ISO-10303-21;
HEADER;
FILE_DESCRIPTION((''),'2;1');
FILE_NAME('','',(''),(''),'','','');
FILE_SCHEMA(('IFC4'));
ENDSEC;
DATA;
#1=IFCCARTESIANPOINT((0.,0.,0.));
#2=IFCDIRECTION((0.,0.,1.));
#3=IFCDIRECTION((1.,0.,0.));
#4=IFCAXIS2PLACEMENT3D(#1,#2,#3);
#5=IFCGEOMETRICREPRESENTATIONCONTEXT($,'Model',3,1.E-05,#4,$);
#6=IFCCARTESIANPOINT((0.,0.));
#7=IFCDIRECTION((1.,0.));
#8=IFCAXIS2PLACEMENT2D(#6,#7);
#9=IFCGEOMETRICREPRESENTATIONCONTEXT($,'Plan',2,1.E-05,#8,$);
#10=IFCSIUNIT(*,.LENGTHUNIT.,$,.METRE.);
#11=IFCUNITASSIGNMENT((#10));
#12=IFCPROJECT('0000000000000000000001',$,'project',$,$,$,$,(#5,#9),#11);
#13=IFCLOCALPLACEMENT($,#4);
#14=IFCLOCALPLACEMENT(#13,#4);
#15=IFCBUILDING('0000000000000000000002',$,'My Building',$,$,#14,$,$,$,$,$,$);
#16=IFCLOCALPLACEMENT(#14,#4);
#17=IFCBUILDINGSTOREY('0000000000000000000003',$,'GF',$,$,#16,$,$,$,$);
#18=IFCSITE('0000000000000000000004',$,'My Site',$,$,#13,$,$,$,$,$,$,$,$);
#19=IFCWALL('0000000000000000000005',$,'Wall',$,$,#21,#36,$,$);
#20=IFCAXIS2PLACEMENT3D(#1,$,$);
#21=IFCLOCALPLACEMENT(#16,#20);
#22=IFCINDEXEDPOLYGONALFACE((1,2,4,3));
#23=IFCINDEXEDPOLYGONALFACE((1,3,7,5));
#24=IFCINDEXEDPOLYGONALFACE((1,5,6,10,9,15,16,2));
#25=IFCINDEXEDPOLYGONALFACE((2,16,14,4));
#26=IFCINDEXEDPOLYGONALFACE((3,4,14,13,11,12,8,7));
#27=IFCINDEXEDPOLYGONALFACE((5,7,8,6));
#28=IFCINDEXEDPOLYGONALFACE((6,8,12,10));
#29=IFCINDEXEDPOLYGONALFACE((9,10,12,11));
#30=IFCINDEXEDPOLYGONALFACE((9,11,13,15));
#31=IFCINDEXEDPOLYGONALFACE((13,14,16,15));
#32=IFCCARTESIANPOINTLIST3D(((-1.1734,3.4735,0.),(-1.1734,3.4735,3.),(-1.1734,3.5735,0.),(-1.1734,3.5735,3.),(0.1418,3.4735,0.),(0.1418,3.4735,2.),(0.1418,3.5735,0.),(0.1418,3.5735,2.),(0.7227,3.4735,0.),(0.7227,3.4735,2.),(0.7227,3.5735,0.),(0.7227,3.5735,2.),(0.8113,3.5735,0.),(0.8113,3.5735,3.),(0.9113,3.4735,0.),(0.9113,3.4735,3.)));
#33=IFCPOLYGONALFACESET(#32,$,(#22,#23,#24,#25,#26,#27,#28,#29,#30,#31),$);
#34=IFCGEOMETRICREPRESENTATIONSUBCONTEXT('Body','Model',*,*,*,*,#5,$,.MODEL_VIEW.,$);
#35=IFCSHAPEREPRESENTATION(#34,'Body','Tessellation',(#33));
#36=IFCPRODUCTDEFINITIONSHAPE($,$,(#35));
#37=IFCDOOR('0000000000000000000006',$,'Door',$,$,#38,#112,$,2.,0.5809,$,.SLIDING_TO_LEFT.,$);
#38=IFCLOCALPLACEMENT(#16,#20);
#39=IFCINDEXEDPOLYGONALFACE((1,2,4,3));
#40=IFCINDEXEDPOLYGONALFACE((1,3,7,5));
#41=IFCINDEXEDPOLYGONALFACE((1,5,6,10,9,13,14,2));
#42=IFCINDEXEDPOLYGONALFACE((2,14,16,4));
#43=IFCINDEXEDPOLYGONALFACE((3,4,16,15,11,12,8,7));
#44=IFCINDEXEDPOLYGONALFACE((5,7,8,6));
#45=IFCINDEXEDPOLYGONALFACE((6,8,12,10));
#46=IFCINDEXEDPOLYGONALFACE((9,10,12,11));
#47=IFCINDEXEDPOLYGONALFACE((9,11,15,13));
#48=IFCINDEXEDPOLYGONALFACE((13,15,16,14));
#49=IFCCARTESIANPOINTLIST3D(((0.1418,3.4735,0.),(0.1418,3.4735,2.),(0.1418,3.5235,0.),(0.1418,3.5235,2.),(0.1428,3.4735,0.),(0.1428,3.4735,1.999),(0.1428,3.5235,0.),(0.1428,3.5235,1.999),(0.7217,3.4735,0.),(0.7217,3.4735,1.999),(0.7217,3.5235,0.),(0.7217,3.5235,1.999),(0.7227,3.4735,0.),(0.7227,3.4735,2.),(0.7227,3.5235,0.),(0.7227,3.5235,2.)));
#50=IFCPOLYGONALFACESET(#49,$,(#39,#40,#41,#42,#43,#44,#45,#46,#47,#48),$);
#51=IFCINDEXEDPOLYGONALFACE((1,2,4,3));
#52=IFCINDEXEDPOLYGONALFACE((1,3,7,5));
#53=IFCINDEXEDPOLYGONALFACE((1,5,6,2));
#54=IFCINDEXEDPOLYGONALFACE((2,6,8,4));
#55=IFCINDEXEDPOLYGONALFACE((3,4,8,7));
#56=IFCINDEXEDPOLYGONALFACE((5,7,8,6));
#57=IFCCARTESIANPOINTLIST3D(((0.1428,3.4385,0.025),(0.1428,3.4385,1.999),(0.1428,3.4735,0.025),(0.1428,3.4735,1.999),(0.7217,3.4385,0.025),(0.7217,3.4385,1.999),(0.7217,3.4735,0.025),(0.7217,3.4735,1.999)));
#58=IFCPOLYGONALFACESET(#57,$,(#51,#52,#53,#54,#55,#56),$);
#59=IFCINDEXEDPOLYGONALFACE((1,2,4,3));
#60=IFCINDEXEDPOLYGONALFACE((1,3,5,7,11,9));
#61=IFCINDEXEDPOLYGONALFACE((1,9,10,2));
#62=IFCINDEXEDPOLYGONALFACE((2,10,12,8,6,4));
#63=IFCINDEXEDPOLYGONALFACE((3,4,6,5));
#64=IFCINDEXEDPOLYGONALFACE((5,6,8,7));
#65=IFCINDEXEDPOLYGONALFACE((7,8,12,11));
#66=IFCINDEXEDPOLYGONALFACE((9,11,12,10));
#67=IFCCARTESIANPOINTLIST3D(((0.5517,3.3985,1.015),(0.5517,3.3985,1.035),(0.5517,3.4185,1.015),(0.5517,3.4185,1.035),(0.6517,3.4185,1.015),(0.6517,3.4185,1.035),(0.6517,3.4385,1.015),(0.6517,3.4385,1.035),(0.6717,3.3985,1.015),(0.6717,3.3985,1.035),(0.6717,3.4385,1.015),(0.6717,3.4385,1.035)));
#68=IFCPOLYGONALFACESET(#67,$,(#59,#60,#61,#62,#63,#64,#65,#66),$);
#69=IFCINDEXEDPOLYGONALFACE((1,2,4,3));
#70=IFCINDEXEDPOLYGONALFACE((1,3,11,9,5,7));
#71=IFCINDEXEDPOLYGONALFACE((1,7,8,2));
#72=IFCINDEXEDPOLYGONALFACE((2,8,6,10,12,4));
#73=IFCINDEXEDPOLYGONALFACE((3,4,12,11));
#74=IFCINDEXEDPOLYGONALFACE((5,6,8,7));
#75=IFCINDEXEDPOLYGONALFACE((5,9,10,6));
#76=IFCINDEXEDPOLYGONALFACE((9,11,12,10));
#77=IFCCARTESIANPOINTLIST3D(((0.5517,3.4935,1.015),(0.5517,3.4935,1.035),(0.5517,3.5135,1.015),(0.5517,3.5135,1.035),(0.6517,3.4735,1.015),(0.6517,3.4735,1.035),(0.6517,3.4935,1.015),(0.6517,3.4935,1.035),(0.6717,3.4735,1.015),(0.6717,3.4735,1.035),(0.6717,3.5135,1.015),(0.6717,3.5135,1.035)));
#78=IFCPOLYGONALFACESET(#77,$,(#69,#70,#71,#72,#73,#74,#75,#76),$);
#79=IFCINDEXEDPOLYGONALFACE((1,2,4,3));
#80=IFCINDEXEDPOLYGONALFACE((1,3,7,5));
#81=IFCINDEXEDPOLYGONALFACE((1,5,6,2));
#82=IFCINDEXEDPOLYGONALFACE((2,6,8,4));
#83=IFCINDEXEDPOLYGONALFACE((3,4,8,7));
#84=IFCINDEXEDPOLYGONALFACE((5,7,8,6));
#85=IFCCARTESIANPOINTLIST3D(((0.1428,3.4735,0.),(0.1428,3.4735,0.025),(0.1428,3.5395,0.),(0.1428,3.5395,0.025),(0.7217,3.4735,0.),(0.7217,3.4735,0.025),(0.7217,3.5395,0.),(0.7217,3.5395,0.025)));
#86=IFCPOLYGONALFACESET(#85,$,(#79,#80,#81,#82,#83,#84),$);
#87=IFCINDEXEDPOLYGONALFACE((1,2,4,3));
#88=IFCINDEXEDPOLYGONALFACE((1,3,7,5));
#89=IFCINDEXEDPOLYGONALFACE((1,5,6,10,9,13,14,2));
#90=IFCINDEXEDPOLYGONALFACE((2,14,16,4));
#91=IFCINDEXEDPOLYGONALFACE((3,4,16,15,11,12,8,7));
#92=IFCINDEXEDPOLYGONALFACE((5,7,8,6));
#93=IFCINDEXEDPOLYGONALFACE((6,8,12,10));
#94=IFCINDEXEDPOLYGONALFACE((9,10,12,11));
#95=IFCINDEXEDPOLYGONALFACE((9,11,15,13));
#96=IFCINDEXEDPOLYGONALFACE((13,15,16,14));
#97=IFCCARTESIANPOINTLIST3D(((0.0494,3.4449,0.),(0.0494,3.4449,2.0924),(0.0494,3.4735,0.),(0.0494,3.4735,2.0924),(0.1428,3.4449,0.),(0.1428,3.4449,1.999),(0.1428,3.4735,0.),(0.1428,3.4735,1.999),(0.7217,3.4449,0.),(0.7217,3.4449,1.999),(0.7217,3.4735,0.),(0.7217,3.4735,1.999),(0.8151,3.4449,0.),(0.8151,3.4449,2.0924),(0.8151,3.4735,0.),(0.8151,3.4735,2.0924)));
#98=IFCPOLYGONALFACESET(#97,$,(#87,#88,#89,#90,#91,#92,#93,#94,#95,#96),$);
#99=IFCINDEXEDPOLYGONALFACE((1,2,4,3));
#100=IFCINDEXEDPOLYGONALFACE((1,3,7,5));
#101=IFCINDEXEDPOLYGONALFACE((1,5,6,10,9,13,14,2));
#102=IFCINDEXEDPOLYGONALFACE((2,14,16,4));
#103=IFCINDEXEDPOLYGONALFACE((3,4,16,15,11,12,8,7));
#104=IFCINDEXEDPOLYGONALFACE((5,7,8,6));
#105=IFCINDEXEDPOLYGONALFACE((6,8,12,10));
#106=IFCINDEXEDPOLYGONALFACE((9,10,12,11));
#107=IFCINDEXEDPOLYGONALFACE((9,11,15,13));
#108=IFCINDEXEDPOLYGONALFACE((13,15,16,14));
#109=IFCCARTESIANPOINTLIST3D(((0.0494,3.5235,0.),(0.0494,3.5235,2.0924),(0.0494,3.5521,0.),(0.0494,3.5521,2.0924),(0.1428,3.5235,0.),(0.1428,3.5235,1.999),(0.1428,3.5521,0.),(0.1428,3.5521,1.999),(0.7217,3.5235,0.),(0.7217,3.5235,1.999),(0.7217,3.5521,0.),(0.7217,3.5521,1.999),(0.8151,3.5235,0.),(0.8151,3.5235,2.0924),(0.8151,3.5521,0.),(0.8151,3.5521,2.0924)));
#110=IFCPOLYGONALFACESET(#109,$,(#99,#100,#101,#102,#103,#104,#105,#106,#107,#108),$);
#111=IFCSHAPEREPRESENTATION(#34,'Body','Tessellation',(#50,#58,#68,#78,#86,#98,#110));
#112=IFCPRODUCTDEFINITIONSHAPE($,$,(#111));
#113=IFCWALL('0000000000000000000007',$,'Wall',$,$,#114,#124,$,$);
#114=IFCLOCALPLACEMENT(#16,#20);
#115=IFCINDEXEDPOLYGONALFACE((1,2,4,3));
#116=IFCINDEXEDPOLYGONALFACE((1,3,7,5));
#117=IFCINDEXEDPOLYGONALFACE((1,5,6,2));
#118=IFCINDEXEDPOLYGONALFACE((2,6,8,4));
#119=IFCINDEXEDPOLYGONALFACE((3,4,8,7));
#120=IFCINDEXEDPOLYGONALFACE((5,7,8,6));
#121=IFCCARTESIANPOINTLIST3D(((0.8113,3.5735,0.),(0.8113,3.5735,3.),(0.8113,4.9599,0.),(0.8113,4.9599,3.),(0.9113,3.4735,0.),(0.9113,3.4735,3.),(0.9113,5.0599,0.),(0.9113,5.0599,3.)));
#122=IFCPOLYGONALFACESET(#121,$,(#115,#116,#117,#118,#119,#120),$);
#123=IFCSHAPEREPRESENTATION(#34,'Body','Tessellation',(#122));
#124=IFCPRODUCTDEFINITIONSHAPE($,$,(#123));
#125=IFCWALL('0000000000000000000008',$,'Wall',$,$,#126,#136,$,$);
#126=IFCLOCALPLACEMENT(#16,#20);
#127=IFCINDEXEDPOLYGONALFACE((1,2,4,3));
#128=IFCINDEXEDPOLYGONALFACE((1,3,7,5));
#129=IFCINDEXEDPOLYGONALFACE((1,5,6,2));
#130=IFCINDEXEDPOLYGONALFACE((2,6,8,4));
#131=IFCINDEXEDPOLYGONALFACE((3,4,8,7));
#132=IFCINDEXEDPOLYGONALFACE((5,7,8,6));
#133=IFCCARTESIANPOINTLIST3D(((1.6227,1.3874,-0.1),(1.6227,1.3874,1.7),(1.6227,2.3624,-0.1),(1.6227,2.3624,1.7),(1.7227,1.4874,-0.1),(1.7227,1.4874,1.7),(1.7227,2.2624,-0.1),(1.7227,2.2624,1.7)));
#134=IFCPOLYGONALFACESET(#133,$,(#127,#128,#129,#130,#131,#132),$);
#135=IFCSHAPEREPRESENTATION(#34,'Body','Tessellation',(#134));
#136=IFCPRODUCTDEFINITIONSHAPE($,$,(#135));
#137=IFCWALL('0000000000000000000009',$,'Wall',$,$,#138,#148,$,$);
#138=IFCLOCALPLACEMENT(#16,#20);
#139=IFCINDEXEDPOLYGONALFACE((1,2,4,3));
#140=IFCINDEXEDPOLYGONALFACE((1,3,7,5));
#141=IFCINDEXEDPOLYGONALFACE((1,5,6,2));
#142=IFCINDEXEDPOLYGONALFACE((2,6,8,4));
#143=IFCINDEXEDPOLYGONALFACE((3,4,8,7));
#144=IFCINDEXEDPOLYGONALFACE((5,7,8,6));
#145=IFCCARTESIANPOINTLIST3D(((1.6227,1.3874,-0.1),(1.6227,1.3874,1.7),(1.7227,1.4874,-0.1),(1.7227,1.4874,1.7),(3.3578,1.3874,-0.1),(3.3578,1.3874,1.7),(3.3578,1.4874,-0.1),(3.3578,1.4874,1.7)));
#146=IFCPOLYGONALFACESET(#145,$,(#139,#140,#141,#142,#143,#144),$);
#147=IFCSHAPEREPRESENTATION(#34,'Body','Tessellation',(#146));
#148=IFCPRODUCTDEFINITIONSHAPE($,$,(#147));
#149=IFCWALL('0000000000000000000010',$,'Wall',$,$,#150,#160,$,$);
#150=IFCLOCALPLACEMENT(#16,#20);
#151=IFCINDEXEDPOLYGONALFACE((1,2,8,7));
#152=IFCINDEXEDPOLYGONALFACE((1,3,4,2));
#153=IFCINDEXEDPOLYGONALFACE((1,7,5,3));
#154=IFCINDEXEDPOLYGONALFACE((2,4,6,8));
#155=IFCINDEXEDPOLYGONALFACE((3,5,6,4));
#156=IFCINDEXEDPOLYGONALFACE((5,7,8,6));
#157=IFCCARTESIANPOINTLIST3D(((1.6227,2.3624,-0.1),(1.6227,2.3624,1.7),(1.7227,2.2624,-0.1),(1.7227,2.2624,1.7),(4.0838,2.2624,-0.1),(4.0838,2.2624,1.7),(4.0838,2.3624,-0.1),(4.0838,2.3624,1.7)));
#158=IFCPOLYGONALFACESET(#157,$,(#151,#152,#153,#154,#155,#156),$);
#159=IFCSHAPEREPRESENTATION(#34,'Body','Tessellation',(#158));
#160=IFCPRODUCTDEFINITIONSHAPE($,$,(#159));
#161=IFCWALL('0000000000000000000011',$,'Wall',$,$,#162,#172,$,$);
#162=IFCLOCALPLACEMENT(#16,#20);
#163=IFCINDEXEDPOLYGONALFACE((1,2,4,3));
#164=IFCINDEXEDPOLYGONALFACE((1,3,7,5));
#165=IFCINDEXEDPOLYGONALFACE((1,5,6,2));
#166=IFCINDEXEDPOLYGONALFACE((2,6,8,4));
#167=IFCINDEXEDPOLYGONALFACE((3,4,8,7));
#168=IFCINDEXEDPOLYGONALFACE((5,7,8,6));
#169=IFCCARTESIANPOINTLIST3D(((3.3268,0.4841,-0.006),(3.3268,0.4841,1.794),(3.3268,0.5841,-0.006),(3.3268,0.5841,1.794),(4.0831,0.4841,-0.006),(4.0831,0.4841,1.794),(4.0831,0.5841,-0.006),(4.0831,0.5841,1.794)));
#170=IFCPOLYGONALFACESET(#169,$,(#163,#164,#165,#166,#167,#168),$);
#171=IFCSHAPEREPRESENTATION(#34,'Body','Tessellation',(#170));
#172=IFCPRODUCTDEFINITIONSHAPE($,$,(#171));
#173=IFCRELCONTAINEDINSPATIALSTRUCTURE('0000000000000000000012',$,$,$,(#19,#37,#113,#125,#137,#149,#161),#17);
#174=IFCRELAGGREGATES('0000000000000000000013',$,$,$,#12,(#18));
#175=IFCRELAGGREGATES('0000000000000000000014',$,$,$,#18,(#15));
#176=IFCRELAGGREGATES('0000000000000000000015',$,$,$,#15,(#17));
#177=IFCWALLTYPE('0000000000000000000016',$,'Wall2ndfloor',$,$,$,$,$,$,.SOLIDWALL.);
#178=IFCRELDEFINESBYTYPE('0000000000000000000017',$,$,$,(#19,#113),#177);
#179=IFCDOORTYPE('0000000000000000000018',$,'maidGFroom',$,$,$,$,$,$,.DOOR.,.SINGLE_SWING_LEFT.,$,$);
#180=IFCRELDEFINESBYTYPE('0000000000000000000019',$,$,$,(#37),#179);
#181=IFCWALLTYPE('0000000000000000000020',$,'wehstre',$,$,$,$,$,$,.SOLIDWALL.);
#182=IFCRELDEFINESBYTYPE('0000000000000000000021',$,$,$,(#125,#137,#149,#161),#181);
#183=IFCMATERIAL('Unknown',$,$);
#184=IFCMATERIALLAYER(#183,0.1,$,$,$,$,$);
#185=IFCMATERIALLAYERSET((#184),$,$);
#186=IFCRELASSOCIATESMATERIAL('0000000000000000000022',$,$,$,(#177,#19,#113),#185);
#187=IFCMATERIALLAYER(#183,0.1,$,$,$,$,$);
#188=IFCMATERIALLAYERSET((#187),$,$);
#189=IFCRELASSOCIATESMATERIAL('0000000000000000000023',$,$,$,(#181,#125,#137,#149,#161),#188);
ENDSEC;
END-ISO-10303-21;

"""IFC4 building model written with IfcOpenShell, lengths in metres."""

from ifc_helpers import new_model, entity, si_unit, frame, origin_with_axes, origin_2d_with_axis, place, context, subcontext, project, spatial, line, indexed_curve, outline, extrude, shape, source, transform, mapped, material, layer, layer_set, layer_usage, type_object, type_shapes, element, fill, save


model = new_model("IFC4")

# Units and contexts
model_context = context("Model", 3, precision=1e-05, world=origin_with_axes())
plan_context = context("Plan", 2, precision=1e-05, world=origin_2d_with_axis())
body_context_1 = subcontext(model_context, "Body", "Model", "MODEL_VIEW")
body_context_2 = subcontext(plan_context, "Body", "Plan", "PLAN_VIEW")
ifc_project = project(units=[si_unit("LENGTHUNIT", "METRE")], contexts=[model_context, plan_context])

# Site, building, storey
site_placement = place(None, origin_with_axes())
site = spatial("IfcSite", under=ifc_project, at=site_placement, Name="My Site")
building_placement = place(site_placement, origin_with_axes())
building = spatial("IfcBuilding", under=site, at=building_placement, Name="My Building")
storey_placement = place(building_placement, origin_with_axes())
storey = spatial("IfcBuildingStorey", under=building, at=storey_placement, Name="GF")

# Shared definitions
ifc_material = material(Name="Unknown")

# Shared definitions
ifc_layer_1 = layer(ifc_material, 0.1)
ifc_layer_set_1 = layer_set([ifc_layer_1])
wall_type_1 = type_object("IfcWallType", Name="Wall2ndfloor", PredefinedType="SOLIDWALL", material=ifc_layer_set_1)

# Wall, opening, door
ifc_layer_usage_1 = layer_usage(ifc_layer_set_1, "AXIS2", "POSITIVE", 0.0)
wall_1_placement = place(storey_placement, frame((0.9113, 3.5735, 0.0), z_axis=(0.0, 0.0, 1.0), x_axis=(-1.0, 0.0, 0.0)))
wall_1 = element("IfcWall", 1, at=wall_1_placement, inside=storey, type_object=wall_type_1, material=ifc_layer_usage_1, Name="Wall", context=body_context_1, shape_type="SweptSolid", body=[
    extrude(outline(indexed_curve([(0.1, 0.0), (0.0, 0.1), (2.0847, 0.1), (2.0847, 0.0)], segments=[line(1, 2, 3, 4, 1)])), origin_with_axes(), (0.0, 0.0, 1.0), 3.0),
])
shared_shape_1 = source(origin_with_axes(), body_context_1, "Body", "SweptSolid", [
    extrude(outline(indexed_curve([(0.0, 0.0), (0.5809, 0.0), (0.5809, 2.0), (0.0, 2.0)], segments=[line(1, 2, 3, 4, 1)])), frame((0.0, -0.6, 0.0), z_axis=(0.0, -1.0, 0.0), x_axis=(1.0, 0.0, 0.0)), (0.0, 0.0, -1.0), 1.2),
])
opening_1_placement = place(wall_1_placement, frame((0.7695, 0.1, 0.0), z_axis=(0.0, 0.0, 1.0), x_axis=(-1.0, 0.0, 0.0)))
opening_1 = element("IfcOpeningElement", 2, at=opening_1_placement, cuts=wall_1, PredefinedType="OPENING", context=body_context_1, shape_type="MappedRepresentation", body=[
    mapped(shared_shape_1, transform((0.0, 0.0, 0.0), x_axis=(1.0, 0.0, 0.0), y_axis=(0.0, 1.0, 0.0), z_axis=(0.0, 0.0, 1.0), scale=1.0)),
])
door_type_1 = type_object("IfcDoorType", Name="maidGFroom", OperationType="SINGLE_SWING_LEFT", PredefinedType="DOOR")
shared_shape_2 = source(origin_with_axes(), body_context_1, "Body", "SweptSolid", [
    extrude(outline(indexed_curve([(0.0, 0.0), (0.0, 2.0), (0.5809, 2.0), (0.5809, 0.0), (0.5799, 0.0), (0.5799, 1.999), (0.001, 1.999), (0.001, 0.0)], segments=[line(1, 2, 3, 4, 5, 6, 7, 8, 1)])), frame((0.0, 0.0, 0.0), z_axis=(0.0, -1.0, 0.0), x_axis=(1.0, 0.0, 0.0)), (0.0, 0.0, -1.0), 0.05),
    extrude(outline(indexed_curve([(0.0, 0.0), (0.5789, 0.0), (0.5789, 0.035), (0.0, 0.035)], segments=[line(1, 2, 3, 4, 1)])), frame((0.001, -0.035, 0.025), z_axis=(0.0, 0.0, 1.0), x_axis=(1.0, 0.0, 0.0)), (0.0, 0.0, 1.0), 1.974),
    extrude(outline(indexed_curve([(0.0, 0.0), (0.0, -0.04), (-0.12, -0.04), (-0.12, -0.02), (-0.02, -0.02), (-0.02, 0.0)], segments=[line(1, 2, 3, 4, 5, 6, 1)])), frame((0.5299, -0.035, 1.015), z_axis=(0.0, 0.0, 1.0), x_axis=(1.0, 0.0, 0.0)), (0.0, 0.0, 1.0), 0.02),
    extrude(outline(indexed_curve([(0.0, 0.0), (0.0, 0.04), (-0.12, 0.04), (-0.12, 0.02), (-0.02, 0.02), (-0.02, 0.0)], segments=[line(1, 2, 3, 4, 5, 6, 1)])), frame((0.5299, 0.0, 1.015), z_axis=(0.0, 0.0, 1.0), x_axis=(1.0, 0.0, 0.0)), (0.0, 0.0, 1.0), 0.02),
    extrude(outline(indexed_curve([(0.0, 0.0), (0.5789, 0.0), (0.5789, 0.066), (0.0, 0.066)], segments=[line(1, 2, 3, 4, 1)])), frame((0.001, 0.0, 0.0), z_axis=(0.0, 0.0, 1.0), x_axis=(1.0, 0.0, 0.0)), (0.0, 0.0, 1.0), 0.025),
    extrude(outline(indexed_curve([(0.0, 0.0), (0.0, 2.0924), (0.7656, 2.0924), (0.7656, 0.0), (0.6723, 0.0), (0.6723, 1.999), (0.0934, 1.999), (0.0934, 0.0)], segments=[line(1, 2, 3, 4, 5, 6, 7, 8, 1)])), frame((-0.0924, -0.0286, 0.0), z_axis=(0.0, -1.0, 0.0), x_axis=(1.0, 0.0, 0.0)), (0.0, 0.0, -1.0), 0.0286),
    extrude(outline(indexed_curve([(0.0, 0.0), (0.0, 2.0924), (0.7656, 2.0924), (0.7656, 0.0), (0.6723, 0.0), (0.6723, 1.999), (0.0934, 1.999), (0.0934, 0.0)], segments=[line(1, 2, 3, 4, 5, 6, 7, 8, 1)])), frame((-0.0924, 0.05, 0.0), z_axis=(0.0, -1.0, 0.0), x_axis=(1.0, 0.0, 0.0)), (0.0, 0.0, -1.0), 0.0286),
])
shared_shape_3 = source(origin_with_axes(), body_context_2, "Body", "Curve2D", [
    entity("IfcIndexedPolyCurve", entity("IfcCartesianPointList2D", [[0.0, 0.0], [0.001, 0.0], [0.001, 0.05], [0.0, 0.05]]), [entity("IfcLineIndex", [1, 2, 3, 4, 1])]),
    entity("IfcIndexedPolyCurve", entity("IfcCartesianPointList2D", [[0.5809, 0.0], [0.5799, 0.0], [0.5799, 0.05], [0.5809, 0.05]]), [entity("IfcLineIndex", [1, 2, 3, 4, 1])]),
    entity("IfcIndexedPolyCurve", entity("IfcCartesianPointList2D", [[-0.2884, -0.035], [0.2904, -0.035], [0.2904, 0.0], [-0.2884, 0.0]]), [entity("IfcLineIndex", [1, 2, 3, 4, 1])]),
])
type_shapes(door_type_1, [shared_shape_2, shared_shape_3])
door_1_placement = place(opening_1_placement, frame((0.0, 0.0, 0.0), z_axis=(0.0, 0.0, 1.0), x_axis=(1.0, 0.0, 0.0)))
door_1 = element("IfcDoor", 3, at=door_1_placement, inside=storey, type_object=door_type_1, Name="Door", OperationType="SLIDING_TO_LEFT", OverallHeight=2.0, OverallWidth=0.5809, shapes=[
    shape(body_context_1, "Body", "MappedRepresentation", [mapped(shared_shape_2, transform((0.0, 0.0, 0.0), x_axis=(1.0, 0.0, 0.0), y_axis=(0.0, 1.0, 0.0), z_axis=(0.0, 0.0, 1.0), scale=1.0))]),
    shape(body_context_2, "Body", "MappedRepresentation", [mapped(shared_shape_3, transform((0.0, 0.0, 0.0), x_axis=(1.0, 0.0, 0.0), y_axis=(0.0, 1.0, 0.0), z_axis=(0.0, 0.0, 1.0), scale=1.0))]),
])
fill(opening_1, door_1)

# Walls
ifc_layer_usage_2 = layer_usage(ifc_layer_set_1, "AXIS2", "POSITIVE", 0.0)
wall_2_placement = place(storey_placement, frame((0.9113, 3.5735, 0.0), z_axis=(0.0, 0.0, 1.0), x_axis=(0.0, 1.0, 0.0)))
element("IfcWall", 4, at=wall_2_placement, inside=storey, type_object=wall_type_1, material=ifc_layer_usage_2, Name="Wall", context=body_context_1, shape_type="SweptSolid", body=[
    extrude(outline(indexed_curve([(-0.1, 0.0), (0.0, 0.1), (1.3864, 0.1), (1.4864, 0.0)], segments=[line(1, 2, 3, 4, 1)])), origin_with_axes(), (0.0, 0.0, 1.0), 3.0),
])
ifc_layer_2 = layer(ifc_material, 0.1)
ifc_layer_set_2 = layer_set([ifc_layer_2])
ifc_layer_usage_3 = layer_usage(ifc_layer_set_2, "AXIS2", "POSITIVE", 0.0)
wall_type_2 = type_object("IfcWallType", Name="wehstre", PredefinedType="SOLIDWALL", material=ifc_layer_set_2)
wall_3_placement = place(storey_placement, frame((1.6227, 2.2624, -0.1), z_axis=(0.0, 0.0, 1.0), x_axis=(0.0, -1.0, 0.0)))
element("IfcWall", 5, at=wall_3_placement, inside=storey, type_object=wall_type_2, material=ifc_layer_usage_3, Name="Wall", context=body_context_1, shape_type="SweptSolid", body=[
    extrude(outline(indexed_curve([(-0.1, 0.0), (0.0, 0.1), (0.775, 0.1), (0.875, 0.0)], segments=[line(1, 2, 3, 4, 1)])), origin_with_axes(), (0.0, 0.0, 1.0), 1.8),
])
ifc_layer_usage_4 = layer_usage(ifc_layer_set_2, "AXIS2", "POSITIVE", 0.0)
wall_4_placement = place(storey_placement, frame((1.6227, 1.3874, -0.1), z_axis=(0.0, 0.0, 1.0), x_axis=(1.0, 0.0, 0.0)))
element("IfcWall", 6, at=wall_4_placement, inside=storey, type_object=wall_type_2, material=ifc_layer_usage_4, Name="Wall", context=body_context_1, shape_type="SweptSolid", body=[
    extrude(outline(indexed_curve([(0.0, 0.0), (0.1, 0.1), (1.735, 0.1), (1.735, 0.0)], segments=[line(1, 2, 3, 4, 1)])), origin_with_axes(), (0.0, 0.0, 1.0), 1.8),
])
ifc_layer_usage_5 = layer_usage(ifc_layer_set_2, "AXIS2", "POSITIVE", 0.0)
wall_5_placement = place(storey_placement, frame((1.6227, 2.2624, -0.1), z_axis=(0.0, 0.0, 1.0), x_axis=(1.0, 0.0, 0.0)))
element("IfcWall", 7, at=wall_5_placement, inside=storey, type_object=wall_type_2, material=ifc_layer_usage_5, Name="Wall", context=body_context_1, shape_type="SweptSolid", body=[
    extrude(outline(indexed_curve([(0.1, 0.0), (0.0, 0.1), (2.461, 0.1), (2.461, 0.0)], segments=[line(1, 2, 3, 4, 1)])), origin_with_axes(), (0.0, 0.0, 1.0), 1.8),
])
ifc_layer_usage_6 = layer_usage(ifc_layer_set_2, "AXIS2", "POSITIVE", 0.0)
wall_6_placement = place(storey_placement, frame((3.3268, 0.4841, -0.006), z_axis=(0.0, 0.0, 1.0), x_axis=(1.0, 0.0, 0.0)))
element("IfcWall", 8, at=wall_6_placement, inside=storey, type_object=wall_type_2, material=ifc_layer_usage_6, Name="Wall", context=body_context_1, shape_type="SweptSolid", body=[
    extrude(outline(indexed_curve([(0.0, 0.0), (0.0, 0.1), (0.7563, 0.1), (0.7563, 0.0)], segments=[line(1, 2, 3, 4, 1)])), origin_with_axes(), (0.0, 0.0, 1.0), 1.8),
])

save(model, "model.ifc")
